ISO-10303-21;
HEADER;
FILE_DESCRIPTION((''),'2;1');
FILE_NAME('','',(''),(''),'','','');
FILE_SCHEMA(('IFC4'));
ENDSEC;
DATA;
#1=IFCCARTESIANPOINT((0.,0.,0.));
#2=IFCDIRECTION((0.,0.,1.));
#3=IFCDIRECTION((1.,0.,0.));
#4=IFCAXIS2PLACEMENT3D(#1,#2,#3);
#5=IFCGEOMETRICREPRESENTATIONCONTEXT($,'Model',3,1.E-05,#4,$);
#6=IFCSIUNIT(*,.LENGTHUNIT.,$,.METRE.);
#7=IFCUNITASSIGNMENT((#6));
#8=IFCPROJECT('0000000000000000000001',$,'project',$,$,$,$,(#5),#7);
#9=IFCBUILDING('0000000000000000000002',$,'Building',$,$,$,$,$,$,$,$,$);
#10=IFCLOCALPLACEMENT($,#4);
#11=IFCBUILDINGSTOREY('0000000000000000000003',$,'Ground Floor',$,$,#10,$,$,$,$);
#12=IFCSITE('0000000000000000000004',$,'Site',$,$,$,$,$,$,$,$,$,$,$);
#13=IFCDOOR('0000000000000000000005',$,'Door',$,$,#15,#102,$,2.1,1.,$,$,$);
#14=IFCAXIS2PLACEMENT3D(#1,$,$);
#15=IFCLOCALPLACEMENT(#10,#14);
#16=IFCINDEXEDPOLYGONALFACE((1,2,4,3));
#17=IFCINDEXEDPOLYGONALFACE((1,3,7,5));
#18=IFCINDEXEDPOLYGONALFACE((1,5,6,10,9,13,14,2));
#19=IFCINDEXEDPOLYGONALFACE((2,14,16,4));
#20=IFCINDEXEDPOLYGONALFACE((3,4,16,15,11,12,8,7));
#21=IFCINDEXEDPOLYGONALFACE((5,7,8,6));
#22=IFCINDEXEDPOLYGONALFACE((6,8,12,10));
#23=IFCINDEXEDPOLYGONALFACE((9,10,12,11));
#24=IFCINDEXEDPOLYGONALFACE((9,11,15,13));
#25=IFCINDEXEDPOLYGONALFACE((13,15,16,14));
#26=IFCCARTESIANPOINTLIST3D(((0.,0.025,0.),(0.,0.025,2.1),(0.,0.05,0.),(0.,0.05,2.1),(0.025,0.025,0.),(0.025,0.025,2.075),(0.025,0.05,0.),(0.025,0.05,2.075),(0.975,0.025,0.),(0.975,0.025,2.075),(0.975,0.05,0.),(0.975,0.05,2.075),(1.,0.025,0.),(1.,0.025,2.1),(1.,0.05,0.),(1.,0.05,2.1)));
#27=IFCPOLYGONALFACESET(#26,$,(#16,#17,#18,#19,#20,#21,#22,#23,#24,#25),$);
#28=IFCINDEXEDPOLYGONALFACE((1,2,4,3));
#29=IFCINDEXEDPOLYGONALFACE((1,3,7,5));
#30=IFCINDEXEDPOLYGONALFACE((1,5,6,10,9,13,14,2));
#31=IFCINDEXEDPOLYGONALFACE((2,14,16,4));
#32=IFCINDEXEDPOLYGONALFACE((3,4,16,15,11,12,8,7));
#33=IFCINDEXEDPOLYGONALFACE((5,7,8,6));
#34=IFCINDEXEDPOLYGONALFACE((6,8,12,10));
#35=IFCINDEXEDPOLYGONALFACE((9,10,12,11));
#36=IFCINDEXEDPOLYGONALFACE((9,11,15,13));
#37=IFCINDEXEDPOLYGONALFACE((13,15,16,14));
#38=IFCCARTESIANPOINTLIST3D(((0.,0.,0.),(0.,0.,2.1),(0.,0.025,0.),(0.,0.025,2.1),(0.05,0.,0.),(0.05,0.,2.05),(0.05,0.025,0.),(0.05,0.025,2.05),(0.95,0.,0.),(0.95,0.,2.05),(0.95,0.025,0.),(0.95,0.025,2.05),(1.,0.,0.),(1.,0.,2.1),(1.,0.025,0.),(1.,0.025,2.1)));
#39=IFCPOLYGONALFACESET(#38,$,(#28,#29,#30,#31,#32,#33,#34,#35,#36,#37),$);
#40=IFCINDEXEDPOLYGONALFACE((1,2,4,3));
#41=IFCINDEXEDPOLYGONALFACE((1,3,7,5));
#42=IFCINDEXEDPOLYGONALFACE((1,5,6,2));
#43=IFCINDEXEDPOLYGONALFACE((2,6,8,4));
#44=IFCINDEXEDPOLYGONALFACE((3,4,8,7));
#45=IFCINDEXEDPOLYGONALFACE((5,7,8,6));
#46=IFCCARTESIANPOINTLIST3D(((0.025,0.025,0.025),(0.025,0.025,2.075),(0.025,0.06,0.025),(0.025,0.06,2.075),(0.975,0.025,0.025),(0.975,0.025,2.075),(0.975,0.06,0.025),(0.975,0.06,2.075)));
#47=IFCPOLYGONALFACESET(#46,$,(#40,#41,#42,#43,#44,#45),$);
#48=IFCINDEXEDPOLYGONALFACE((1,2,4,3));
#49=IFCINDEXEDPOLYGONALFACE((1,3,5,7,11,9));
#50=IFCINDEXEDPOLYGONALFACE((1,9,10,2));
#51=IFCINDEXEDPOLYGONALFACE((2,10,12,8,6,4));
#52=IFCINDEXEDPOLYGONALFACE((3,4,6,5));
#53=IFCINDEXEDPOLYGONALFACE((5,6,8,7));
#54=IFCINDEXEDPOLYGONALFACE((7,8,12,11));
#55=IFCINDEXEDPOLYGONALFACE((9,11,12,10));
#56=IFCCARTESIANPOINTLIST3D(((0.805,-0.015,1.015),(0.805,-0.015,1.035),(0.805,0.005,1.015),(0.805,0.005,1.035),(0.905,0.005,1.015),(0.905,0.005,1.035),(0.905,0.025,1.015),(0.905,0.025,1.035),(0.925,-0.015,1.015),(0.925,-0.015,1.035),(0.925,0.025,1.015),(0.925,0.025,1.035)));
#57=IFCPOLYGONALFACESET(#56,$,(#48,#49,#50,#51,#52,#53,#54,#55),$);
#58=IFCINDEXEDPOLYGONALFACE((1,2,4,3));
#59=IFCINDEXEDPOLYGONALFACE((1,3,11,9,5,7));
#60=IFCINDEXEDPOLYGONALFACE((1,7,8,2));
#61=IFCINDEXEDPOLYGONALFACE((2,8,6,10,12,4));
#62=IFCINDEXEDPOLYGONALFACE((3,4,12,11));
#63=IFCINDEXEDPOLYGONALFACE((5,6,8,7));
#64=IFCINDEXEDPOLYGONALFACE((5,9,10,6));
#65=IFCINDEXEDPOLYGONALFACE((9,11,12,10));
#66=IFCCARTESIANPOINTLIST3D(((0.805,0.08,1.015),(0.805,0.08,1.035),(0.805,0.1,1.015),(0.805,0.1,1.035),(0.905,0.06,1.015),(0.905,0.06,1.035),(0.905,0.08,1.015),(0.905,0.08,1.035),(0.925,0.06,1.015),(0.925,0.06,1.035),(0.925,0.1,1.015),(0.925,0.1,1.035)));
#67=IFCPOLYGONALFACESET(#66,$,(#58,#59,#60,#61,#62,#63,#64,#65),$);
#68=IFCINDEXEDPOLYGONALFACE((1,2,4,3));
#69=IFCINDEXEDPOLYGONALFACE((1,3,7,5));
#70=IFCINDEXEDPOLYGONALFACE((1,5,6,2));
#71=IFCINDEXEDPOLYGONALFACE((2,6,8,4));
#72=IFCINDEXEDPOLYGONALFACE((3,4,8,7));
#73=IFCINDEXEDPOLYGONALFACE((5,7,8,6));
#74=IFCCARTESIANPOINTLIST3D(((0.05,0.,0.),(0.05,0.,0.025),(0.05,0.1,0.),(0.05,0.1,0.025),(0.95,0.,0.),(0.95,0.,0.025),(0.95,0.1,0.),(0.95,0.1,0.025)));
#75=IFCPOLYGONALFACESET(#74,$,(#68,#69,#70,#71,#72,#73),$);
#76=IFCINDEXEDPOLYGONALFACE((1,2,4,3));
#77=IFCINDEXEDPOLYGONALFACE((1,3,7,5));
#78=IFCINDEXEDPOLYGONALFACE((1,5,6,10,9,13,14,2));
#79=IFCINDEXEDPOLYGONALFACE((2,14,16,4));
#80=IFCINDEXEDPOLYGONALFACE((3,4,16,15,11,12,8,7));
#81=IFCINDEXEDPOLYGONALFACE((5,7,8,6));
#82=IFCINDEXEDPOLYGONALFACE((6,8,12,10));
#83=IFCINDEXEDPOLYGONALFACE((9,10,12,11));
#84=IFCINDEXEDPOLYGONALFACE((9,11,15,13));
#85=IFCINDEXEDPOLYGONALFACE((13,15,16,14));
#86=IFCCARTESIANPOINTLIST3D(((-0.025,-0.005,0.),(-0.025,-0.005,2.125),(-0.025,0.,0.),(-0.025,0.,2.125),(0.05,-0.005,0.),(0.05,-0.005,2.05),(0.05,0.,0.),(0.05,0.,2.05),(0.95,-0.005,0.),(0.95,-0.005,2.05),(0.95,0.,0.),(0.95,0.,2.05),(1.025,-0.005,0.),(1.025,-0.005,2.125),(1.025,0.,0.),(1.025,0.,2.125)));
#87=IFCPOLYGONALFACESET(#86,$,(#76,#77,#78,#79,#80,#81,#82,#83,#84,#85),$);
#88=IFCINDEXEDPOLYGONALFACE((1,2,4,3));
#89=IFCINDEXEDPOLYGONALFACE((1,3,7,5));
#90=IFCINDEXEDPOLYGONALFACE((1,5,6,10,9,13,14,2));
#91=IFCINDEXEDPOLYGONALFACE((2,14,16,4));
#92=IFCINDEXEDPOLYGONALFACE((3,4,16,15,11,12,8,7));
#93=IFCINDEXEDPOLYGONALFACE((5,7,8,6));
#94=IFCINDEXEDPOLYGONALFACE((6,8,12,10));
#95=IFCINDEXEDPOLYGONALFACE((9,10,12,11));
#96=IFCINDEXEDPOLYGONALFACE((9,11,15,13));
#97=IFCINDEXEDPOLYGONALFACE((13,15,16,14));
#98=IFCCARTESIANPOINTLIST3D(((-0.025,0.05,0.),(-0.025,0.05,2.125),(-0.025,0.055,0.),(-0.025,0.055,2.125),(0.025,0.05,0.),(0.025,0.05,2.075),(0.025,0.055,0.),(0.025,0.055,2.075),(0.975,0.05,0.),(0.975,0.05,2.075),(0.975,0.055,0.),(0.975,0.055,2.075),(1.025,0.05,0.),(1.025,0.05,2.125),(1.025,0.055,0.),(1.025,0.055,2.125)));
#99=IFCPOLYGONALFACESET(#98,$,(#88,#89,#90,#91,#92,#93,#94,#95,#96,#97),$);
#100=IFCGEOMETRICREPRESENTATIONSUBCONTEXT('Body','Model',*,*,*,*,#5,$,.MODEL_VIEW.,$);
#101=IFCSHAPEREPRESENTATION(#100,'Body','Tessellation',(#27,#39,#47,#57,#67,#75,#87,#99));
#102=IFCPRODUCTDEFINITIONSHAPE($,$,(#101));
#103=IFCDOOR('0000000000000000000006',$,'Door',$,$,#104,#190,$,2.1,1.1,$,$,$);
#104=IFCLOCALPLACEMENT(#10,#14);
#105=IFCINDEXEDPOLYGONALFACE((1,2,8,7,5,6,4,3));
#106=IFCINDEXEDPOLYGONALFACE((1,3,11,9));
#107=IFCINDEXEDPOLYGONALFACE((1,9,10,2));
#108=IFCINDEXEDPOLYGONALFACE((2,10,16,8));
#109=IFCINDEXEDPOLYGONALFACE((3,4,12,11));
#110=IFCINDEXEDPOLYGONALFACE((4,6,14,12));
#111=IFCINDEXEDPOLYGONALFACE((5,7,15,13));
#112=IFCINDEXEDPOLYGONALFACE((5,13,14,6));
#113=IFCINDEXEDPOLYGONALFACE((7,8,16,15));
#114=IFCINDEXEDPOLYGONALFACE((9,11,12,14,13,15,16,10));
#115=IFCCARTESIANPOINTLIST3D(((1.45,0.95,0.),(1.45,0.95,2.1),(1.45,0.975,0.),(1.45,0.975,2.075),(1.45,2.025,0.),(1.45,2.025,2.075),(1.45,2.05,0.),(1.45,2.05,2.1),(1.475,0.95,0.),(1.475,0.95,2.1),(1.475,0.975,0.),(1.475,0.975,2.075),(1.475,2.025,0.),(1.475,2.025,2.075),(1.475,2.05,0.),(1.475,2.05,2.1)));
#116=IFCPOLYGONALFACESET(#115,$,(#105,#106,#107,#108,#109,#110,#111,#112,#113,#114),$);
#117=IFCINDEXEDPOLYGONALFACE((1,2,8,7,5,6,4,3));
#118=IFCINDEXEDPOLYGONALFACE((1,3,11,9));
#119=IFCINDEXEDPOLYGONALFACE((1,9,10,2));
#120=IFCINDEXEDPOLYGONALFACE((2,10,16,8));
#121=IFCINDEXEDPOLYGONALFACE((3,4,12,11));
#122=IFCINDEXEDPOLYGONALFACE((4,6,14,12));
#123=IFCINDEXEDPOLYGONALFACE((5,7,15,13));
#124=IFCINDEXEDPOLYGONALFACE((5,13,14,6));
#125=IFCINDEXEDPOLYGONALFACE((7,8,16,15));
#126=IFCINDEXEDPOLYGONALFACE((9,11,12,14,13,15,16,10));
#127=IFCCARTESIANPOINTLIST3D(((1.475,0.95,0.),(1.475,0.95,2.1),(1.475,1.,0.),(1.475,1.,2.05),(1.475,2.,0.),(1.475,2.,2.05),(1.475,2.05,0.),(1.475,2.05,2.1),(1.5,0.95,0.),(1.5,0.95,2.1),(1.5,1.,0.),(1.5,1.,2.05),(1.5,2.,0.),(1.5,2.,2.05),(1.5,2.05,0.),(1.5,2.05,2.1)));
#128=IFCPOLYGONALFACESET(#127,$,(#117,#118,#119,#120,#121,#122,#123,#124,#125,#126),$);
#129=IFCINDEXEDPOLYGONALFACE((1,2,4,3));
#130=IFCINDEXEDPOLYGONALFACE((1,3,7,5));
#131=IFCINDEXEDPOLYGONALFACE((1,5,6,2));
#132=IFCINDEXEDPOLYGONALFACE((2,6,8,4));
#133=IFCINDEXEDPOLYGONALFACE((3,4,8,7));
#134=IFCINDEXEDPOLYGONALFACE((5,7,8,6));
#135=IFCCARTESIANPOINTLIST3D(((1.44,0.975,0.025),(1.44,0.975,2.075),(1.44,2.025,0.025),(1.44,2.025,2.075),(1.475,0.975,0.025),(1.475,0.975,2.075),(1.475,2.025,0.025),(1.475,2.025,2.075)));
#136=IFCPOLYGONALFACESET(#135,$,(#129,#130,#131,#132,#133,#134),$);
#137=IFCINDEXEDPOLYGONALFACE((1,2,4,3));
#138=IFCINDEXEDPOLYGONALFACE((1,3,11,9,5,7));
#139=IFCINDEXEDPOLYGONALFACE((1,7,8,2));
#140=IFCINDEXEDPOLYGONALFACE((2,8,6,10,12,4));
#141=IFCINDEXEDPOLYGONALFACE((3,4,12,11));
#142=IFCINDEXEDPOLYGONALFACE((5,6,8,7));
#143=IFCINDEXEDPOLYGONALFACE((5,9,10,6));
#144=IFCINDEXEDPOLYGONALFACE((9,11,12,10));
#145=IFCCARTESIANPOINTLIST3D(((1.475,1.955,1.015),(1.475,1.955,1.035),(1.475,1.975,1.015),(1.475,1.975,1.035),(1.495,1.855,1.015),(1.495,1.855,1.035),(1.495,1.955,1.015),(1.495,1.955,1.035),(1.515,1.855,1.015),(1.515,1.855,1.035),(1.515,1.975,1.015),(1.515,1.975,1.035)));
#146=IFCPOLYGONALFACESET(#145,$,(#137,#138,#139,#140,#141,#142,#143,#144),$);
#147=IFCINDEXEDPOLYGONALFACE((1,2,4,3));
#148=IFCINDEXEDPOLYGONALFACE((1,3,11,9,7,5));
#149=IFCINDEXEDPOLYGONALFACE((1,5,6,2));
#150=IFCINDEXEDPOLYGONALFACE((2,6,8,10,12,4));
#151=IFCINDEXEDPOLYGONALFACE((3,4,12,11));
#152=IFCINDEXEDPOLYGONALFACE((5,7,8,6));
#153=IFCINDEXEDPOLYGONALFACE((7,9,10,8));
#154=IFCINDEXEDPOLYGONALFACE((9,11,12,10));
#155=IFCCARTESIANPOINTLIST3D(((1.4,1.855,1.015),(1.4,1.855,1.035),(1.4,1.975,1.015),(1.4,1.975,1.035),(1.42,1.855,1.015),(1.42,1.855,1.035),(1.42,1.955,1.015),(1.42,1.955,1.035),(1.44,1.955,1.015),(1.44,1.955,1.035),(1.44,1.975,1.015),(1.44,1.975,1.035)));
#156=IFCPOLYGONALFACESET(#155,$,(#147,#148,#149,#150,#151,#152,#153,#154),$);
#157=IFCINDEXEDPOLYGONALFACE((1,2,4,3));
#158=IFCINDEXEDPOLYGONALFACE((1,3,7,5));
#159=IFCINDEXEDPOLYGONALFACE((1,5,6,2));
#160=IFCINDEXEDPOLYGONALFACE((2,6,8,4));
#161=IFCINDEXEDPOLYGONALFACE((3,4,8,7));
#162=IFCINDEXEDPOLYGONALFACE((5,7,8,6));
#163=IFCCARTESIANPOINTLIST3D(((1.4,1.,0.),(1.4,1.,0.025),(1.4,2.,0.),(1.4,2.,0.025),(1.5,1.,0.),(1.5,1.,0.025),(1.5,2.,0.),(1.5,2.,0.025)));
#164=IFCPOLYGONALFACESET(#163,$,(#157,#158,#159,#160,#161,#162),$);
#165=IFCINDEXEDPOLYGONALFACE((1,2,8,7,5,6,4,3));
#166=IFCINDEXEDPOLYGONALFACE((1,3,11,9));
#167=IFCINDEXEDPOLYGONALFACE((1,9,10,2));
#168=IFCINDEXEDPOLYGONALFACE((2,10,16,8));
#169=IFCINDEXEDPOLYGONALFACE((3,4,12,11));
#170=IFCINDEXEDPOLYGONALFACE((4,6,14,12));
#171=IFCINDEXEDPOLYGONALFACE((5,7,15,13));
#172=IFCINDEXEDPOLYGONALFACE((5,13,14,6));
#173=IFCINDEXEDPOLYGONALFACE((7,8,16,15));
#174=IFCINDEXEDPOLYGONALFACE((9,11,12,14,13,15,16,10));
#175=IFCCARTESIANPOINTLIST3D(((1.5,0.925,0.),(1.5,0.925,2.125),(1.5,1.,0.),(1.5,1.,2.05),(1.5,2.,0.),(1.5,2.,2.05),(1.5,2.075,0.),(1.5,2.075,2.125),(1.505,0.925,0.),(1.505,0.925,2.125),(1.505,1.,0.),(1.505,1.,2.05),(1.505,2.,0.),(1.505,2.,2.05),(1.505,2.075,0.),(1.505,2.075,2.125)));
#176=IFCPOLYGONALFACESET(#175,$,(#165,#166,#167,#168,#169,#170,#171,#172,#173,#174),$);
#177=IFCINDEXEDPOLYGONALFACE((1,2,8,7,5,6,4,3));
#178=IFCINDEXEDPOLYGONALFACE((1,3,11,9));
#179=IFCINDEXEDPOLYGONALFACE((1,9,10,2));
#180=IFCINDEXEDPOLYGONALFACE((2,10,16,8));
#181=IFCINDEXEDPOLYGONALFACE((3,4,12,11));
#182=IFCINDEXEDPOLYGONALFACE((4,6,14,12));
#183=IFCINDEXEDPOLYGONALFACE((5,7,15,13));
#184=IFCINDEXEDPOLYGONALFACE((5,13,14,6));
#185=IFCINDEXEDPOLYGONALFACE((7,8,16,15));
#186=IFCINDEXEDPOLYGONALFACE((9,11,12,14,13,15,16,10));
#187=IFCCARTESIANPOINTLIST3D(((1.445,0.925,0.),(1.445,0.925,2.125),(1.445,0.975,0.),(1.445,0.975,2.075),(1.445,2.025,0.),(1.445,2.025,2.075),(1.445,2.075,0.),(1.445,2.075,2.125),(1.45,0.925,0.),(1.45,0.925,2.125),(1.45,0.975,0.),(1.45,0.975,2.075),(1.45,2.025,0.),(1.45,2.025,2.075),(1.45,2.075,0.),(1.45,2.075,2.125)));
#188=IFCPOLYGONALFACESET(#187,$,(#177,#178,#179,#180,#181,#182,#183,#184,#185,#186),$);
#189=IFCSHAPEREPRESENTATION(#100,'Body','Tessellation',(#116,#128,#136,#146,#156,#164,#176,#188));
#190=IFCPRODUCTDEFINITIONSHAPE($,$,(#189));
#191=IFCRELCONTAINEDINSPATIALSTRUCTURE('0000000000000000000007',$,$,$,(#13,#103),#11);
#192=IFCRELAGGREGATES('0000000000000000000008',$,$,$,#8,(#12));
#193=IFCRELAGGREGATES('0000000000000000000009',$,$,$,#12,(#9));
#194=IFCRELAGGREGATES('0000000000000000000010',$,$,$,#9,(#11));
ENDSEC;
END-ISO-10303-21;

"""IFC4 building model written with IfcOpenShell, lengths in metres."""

from ifc_helpers import new_model, si_unit, frame, origin_with_axes, place, context, subcontext, project, spatial, line, indexed_curve, outline, extrude, element, save


model = new_model("IFC4")

# Units and contexts
model_context = context("Model", 3, precision=1e-05, world=origin_with_axes())
body_context = subcontext(model_context, "Body", "Model", "MODEL_VIEW")
ifc_project = project(units=[si_unit("LENGTHUNIT", "METRE")], contexts=[model_context])

# Site, building, storey
site = spatial("IfcSite", under=ifc_project, Name="Site")
building = spatial("IfcBuilding", under=site, Name="Building")
storey_placement = place(None, origin_with_axes())
storey = spatial("IfcBuildingStorey", under=building, at=storey_placement, Name="Ground Floor")

# Doors
door_1_placement = place(storey_placement, origin_with_axes())
element("IfcDoor", 1, at=door_1_placement, inside=storey, Name="Door", OverallHeight=2.1, OverallWidth=1.0, context=body_context, shape_type="SweptSolid", body=[
    extrude(outline(indexed_curve([(0.0, 0.0), (0.0, 2.1), (1.0, 2.1), (1.0, 0.0), (0.975, 0.0), (0.975, 2.075), (0.025, 2.075), (0.025, 0.0)], segments=[line(1, 2, 3, 4, 5, 6, 7, 8, 1)])), frame((0.0, 0.025, 0.0), z_axis=(0.0, -1.0, 0.0), x_axis=(1.0, 0.0, 0.0)), (0.0, 0.0, -1.0), 0.025),
    extrude(outline(indexed_curve([(0.0, 0.0), (0.0, 2.1), (1.0, 2.1), (1.0, 0.0), (0.95, 0.0), (0.95, 2.05), (0.05, 2.05), (0.05, 0.0)], segments=[line(1, 2, 3, 4, 5, 6, 7, 8, 1)])), frame((0.0, 0.0, 0.0), z_axis=(0.0, -1.0, 0.0), x_axis=(1.0, 0.0, 0.0)), (0.0, 0.0, -1.0), 0.025),
    extrude(outline(indexed_curve([(0.0, 0.0), (0.95, 0.0), (0.95, 0.035), (0.0, 0.035)], segments=[line(1, 2, 3, 4, 1)])), frame((0.025, 0.025, 0.025), z_axis=(0.0, 0.0, 1.0), x_axis=(1.0, 0.0, 0.0)), (0.0, 0.0, 1.0), 2.05),
    extrude(outline(indexed_curve([(0.0, 0.0), (0.0, -0.04), (-0.12, -0.04), (-0.12, -0.02), (-0.02, -0.02), (-0.02, 0.0)], segments=[line(1, 2, 3, 4, 5, 6, 1)])), frame((0.925, 0.025, 1.015), z_axis=(0.0, 0.0, 1.0), x_axis=(1.0, 0.0, 0.0)), (0.0, 0.0, 1.0), 0.02),
    extrude(outline(indexed_curve([(0.0, 0.0), (0.0, 0.04), (-0.12, 0.04), (-0.12, 0.02), (-0.02, 0.02), (-0.02, 0.0)], segments=[line(1, 2, 3, 4, 5, 6, 1)])), frame((0.925, 0.06, 1.015), z_axis=(0.0, 0.0, 1.0), x_axis=(1.0, 0.0, 0.0)), (0.0, 0.0, 1.0), 0.02),
    extrude(outline(indexed_curve([(0.0, 0.0), (0.9, 0.0), (0.9, 0.1), (0.0, 0.1)], segments=[line(1, 2, 3, 4, 1)])), frame((0.05, 0.0, 0.0), z_axis=(0.0, 0.0, 1.0), x_axis=(1.0, 0.0, 0.0)), (0.0, 0.0, 1.0), 0.025),
    extrude(outline(indexed_curve([(0.0, 0.0), (0.0, 2.125), (1.05, 2.125), (1.05, 0.0), (0.975, 0.0), (0.975, 2.05), (0.075, 2.05), (0.075, 0.0)], segments=[line(1, 2, 3, 4, 5, 6, 7, 8, 1)])), frame((-0.025, -0.005, 0.0), z_axis=(0.0, -1.0, 0.0), x_axis=(1.0, 0.0, 0.0)), (0.0, 0.0, -1.0), 0.005),
    extrude(outline(indexed_curve([(0.0, 0.0), (0.0, 2.125), (1.05, 2.125), (1.05, 0.0), (1.0, 0.0), (1.0, 2.075), (0.05, 2.075), (0.05, 0.0)], segments=[line(1, 2, 3, 4, 5, 6, 7, 8, 1)])), frame((-0.025, 0.05, 0.0), z_axis=(0.0, -1.0, 0.0), x_axis=(1.0, 0.0, 0.0)), (0.0, 0.0, -1.0), 0.005),
])
door_2_placement = place(storey_placement, frame((1.5, 0.95, 0.0), z_axis=(0.0, 0.0, 1.0), x_axis=(0.0, 1.0, 0.0)))
element("IfcDoor", 2, at=door_2_placement, inside=storey, Name="Door", OverallHeight=2.1, OverallWidth=1.1, context=body_context, shape_type="SweptSolid", body=[
    extrude(outline(indexed_curve([(0.0, 0.0), (0.0, 2.1), (1.1, 2.1), (1.1, 0.0), (1.075, 0.0), (1.075, 2.075), (0.025, 2.075), (0.025, 0.0)], segments=[line(1, 2, 3, 4, 5, 6, 7, 8, 1)])), frame((0.0, 0.025, 0.0), z_axis=(0.0, -1.0, 0.0), x_axis=(1.0, 0.0, 0.0)), (0.0, 0.0, -1.0), 0.025),
    extrude(outline(indexed_curve([(0.0, 0.0), (0.0, 2.1), (1.1, 2.1), (1.1, 0.0), (1.05, 0.0), (1.05, 2.05), (0.05, 2.05), (0.05, 0.0)], segments=[line(1, 2, 3, 4, 5, 6, 7, 8, 1)])), frame((0.0, 0.0, 0.0), z_axis=(0.0, -1.0, 0.0), x_axis=(1.0, 0.0, 0.0)), (0.0, 0.0, -1.0), 0.025),
    extrude(outline(indexed_curve([(0.0, 0.0), (1.05, 0.0), (1.05, 0.035), (0.0, 0.035)], segments=[line(1, 2, 3, 4, 1)])), frame((0.025, 0.025, 0.025), z_axis=(0.0, 0.0, 1.0), x_axis=(1.0, 0.0, 0.0)), (0.0, 0.0, 1.0), 2.05),
    extrude(outline(indexed_curve([(0.0, 0.0), (0.0, -0.04), (-0.12, -0.04), (-0.12, -0.02), (-0.02, -0.02), (-0.02, 0.0)], segments=[line(1, 2, 3, 4, 5, 6, 1)])), frame((1.025, 0.025, 1.015), z_axis=(0.0, 0.0, 1.0), x_axis=(1.0, 0.0, 0.0)), (0.0, 0.0, 1.0), 0.02),
    extrude(outline(indexed_curve([(0.0, 0.0), (0.0, 0.04), (-0.12, 0.04), (-0.12, 0.02), (-0.02, 0.02), (-0.02, 0.0)], segments=[line(1, 2, 3, 4, 5, 6, 1)])), frame((1.025, 0.06, 1.015), z_axis=(0.0, 0.0, 1.0), x_axis=(1.0, 0.0, 0.0)), (0.0, 0.0, 1.0), 0.02),
    extrude(outline(indexed_curve([(0.0, 0.0), (1.0, 0.0), (1.0, 0.1), (0.0, 0.1)], segments=[line(1, 2, 3, 4, 1)])), frame((0.05, 0.0, 0.0), z_axis=(0.0, 0.0, 1.0), x_axis=(1.0, 0.0, 0.0)), (0.0, 0.0, 1.0), 0.025),
    extrude(outline(indexed_curve([(0.0, 0.0), (0.0, 2.125), (1.15, 2.125), (1.15, 0.0), (1.075, 0.0), (1.075, 2.05), (0.075, 2.05), (0.075, 0.0)], segments=[line(1, 2, 3, 4, 5, 6, 7, 8, 1)])), frame((-0.025, -0.005, 0.0), z_axis=(0.0, -1.0, 0.0), x_axis=(1.0, 0.0, 0.0)), (0.0, 0.0, -1.0), 0.005),
    extrude(outline(indexed_curve([(0.0, 0.0), (0.0, 2.125), (1.15, 2.125), (1.15, 0.0), (1.1, 0.0), (1.1, 2.075), (0.05, 2.075), (0.05, 0.0)], segments=[line(1, 2, 3, 4, 5, 6, 7, 8, 1)])), frame((-0.025, 0.05, 0.0), z_axis=(0.0, -1.0, 0.0), x_axis=(1.0, 0.0, 0.0)), (0.0, 0.0, -1.0), 0.005),
])

save(model, "model.ifc")
